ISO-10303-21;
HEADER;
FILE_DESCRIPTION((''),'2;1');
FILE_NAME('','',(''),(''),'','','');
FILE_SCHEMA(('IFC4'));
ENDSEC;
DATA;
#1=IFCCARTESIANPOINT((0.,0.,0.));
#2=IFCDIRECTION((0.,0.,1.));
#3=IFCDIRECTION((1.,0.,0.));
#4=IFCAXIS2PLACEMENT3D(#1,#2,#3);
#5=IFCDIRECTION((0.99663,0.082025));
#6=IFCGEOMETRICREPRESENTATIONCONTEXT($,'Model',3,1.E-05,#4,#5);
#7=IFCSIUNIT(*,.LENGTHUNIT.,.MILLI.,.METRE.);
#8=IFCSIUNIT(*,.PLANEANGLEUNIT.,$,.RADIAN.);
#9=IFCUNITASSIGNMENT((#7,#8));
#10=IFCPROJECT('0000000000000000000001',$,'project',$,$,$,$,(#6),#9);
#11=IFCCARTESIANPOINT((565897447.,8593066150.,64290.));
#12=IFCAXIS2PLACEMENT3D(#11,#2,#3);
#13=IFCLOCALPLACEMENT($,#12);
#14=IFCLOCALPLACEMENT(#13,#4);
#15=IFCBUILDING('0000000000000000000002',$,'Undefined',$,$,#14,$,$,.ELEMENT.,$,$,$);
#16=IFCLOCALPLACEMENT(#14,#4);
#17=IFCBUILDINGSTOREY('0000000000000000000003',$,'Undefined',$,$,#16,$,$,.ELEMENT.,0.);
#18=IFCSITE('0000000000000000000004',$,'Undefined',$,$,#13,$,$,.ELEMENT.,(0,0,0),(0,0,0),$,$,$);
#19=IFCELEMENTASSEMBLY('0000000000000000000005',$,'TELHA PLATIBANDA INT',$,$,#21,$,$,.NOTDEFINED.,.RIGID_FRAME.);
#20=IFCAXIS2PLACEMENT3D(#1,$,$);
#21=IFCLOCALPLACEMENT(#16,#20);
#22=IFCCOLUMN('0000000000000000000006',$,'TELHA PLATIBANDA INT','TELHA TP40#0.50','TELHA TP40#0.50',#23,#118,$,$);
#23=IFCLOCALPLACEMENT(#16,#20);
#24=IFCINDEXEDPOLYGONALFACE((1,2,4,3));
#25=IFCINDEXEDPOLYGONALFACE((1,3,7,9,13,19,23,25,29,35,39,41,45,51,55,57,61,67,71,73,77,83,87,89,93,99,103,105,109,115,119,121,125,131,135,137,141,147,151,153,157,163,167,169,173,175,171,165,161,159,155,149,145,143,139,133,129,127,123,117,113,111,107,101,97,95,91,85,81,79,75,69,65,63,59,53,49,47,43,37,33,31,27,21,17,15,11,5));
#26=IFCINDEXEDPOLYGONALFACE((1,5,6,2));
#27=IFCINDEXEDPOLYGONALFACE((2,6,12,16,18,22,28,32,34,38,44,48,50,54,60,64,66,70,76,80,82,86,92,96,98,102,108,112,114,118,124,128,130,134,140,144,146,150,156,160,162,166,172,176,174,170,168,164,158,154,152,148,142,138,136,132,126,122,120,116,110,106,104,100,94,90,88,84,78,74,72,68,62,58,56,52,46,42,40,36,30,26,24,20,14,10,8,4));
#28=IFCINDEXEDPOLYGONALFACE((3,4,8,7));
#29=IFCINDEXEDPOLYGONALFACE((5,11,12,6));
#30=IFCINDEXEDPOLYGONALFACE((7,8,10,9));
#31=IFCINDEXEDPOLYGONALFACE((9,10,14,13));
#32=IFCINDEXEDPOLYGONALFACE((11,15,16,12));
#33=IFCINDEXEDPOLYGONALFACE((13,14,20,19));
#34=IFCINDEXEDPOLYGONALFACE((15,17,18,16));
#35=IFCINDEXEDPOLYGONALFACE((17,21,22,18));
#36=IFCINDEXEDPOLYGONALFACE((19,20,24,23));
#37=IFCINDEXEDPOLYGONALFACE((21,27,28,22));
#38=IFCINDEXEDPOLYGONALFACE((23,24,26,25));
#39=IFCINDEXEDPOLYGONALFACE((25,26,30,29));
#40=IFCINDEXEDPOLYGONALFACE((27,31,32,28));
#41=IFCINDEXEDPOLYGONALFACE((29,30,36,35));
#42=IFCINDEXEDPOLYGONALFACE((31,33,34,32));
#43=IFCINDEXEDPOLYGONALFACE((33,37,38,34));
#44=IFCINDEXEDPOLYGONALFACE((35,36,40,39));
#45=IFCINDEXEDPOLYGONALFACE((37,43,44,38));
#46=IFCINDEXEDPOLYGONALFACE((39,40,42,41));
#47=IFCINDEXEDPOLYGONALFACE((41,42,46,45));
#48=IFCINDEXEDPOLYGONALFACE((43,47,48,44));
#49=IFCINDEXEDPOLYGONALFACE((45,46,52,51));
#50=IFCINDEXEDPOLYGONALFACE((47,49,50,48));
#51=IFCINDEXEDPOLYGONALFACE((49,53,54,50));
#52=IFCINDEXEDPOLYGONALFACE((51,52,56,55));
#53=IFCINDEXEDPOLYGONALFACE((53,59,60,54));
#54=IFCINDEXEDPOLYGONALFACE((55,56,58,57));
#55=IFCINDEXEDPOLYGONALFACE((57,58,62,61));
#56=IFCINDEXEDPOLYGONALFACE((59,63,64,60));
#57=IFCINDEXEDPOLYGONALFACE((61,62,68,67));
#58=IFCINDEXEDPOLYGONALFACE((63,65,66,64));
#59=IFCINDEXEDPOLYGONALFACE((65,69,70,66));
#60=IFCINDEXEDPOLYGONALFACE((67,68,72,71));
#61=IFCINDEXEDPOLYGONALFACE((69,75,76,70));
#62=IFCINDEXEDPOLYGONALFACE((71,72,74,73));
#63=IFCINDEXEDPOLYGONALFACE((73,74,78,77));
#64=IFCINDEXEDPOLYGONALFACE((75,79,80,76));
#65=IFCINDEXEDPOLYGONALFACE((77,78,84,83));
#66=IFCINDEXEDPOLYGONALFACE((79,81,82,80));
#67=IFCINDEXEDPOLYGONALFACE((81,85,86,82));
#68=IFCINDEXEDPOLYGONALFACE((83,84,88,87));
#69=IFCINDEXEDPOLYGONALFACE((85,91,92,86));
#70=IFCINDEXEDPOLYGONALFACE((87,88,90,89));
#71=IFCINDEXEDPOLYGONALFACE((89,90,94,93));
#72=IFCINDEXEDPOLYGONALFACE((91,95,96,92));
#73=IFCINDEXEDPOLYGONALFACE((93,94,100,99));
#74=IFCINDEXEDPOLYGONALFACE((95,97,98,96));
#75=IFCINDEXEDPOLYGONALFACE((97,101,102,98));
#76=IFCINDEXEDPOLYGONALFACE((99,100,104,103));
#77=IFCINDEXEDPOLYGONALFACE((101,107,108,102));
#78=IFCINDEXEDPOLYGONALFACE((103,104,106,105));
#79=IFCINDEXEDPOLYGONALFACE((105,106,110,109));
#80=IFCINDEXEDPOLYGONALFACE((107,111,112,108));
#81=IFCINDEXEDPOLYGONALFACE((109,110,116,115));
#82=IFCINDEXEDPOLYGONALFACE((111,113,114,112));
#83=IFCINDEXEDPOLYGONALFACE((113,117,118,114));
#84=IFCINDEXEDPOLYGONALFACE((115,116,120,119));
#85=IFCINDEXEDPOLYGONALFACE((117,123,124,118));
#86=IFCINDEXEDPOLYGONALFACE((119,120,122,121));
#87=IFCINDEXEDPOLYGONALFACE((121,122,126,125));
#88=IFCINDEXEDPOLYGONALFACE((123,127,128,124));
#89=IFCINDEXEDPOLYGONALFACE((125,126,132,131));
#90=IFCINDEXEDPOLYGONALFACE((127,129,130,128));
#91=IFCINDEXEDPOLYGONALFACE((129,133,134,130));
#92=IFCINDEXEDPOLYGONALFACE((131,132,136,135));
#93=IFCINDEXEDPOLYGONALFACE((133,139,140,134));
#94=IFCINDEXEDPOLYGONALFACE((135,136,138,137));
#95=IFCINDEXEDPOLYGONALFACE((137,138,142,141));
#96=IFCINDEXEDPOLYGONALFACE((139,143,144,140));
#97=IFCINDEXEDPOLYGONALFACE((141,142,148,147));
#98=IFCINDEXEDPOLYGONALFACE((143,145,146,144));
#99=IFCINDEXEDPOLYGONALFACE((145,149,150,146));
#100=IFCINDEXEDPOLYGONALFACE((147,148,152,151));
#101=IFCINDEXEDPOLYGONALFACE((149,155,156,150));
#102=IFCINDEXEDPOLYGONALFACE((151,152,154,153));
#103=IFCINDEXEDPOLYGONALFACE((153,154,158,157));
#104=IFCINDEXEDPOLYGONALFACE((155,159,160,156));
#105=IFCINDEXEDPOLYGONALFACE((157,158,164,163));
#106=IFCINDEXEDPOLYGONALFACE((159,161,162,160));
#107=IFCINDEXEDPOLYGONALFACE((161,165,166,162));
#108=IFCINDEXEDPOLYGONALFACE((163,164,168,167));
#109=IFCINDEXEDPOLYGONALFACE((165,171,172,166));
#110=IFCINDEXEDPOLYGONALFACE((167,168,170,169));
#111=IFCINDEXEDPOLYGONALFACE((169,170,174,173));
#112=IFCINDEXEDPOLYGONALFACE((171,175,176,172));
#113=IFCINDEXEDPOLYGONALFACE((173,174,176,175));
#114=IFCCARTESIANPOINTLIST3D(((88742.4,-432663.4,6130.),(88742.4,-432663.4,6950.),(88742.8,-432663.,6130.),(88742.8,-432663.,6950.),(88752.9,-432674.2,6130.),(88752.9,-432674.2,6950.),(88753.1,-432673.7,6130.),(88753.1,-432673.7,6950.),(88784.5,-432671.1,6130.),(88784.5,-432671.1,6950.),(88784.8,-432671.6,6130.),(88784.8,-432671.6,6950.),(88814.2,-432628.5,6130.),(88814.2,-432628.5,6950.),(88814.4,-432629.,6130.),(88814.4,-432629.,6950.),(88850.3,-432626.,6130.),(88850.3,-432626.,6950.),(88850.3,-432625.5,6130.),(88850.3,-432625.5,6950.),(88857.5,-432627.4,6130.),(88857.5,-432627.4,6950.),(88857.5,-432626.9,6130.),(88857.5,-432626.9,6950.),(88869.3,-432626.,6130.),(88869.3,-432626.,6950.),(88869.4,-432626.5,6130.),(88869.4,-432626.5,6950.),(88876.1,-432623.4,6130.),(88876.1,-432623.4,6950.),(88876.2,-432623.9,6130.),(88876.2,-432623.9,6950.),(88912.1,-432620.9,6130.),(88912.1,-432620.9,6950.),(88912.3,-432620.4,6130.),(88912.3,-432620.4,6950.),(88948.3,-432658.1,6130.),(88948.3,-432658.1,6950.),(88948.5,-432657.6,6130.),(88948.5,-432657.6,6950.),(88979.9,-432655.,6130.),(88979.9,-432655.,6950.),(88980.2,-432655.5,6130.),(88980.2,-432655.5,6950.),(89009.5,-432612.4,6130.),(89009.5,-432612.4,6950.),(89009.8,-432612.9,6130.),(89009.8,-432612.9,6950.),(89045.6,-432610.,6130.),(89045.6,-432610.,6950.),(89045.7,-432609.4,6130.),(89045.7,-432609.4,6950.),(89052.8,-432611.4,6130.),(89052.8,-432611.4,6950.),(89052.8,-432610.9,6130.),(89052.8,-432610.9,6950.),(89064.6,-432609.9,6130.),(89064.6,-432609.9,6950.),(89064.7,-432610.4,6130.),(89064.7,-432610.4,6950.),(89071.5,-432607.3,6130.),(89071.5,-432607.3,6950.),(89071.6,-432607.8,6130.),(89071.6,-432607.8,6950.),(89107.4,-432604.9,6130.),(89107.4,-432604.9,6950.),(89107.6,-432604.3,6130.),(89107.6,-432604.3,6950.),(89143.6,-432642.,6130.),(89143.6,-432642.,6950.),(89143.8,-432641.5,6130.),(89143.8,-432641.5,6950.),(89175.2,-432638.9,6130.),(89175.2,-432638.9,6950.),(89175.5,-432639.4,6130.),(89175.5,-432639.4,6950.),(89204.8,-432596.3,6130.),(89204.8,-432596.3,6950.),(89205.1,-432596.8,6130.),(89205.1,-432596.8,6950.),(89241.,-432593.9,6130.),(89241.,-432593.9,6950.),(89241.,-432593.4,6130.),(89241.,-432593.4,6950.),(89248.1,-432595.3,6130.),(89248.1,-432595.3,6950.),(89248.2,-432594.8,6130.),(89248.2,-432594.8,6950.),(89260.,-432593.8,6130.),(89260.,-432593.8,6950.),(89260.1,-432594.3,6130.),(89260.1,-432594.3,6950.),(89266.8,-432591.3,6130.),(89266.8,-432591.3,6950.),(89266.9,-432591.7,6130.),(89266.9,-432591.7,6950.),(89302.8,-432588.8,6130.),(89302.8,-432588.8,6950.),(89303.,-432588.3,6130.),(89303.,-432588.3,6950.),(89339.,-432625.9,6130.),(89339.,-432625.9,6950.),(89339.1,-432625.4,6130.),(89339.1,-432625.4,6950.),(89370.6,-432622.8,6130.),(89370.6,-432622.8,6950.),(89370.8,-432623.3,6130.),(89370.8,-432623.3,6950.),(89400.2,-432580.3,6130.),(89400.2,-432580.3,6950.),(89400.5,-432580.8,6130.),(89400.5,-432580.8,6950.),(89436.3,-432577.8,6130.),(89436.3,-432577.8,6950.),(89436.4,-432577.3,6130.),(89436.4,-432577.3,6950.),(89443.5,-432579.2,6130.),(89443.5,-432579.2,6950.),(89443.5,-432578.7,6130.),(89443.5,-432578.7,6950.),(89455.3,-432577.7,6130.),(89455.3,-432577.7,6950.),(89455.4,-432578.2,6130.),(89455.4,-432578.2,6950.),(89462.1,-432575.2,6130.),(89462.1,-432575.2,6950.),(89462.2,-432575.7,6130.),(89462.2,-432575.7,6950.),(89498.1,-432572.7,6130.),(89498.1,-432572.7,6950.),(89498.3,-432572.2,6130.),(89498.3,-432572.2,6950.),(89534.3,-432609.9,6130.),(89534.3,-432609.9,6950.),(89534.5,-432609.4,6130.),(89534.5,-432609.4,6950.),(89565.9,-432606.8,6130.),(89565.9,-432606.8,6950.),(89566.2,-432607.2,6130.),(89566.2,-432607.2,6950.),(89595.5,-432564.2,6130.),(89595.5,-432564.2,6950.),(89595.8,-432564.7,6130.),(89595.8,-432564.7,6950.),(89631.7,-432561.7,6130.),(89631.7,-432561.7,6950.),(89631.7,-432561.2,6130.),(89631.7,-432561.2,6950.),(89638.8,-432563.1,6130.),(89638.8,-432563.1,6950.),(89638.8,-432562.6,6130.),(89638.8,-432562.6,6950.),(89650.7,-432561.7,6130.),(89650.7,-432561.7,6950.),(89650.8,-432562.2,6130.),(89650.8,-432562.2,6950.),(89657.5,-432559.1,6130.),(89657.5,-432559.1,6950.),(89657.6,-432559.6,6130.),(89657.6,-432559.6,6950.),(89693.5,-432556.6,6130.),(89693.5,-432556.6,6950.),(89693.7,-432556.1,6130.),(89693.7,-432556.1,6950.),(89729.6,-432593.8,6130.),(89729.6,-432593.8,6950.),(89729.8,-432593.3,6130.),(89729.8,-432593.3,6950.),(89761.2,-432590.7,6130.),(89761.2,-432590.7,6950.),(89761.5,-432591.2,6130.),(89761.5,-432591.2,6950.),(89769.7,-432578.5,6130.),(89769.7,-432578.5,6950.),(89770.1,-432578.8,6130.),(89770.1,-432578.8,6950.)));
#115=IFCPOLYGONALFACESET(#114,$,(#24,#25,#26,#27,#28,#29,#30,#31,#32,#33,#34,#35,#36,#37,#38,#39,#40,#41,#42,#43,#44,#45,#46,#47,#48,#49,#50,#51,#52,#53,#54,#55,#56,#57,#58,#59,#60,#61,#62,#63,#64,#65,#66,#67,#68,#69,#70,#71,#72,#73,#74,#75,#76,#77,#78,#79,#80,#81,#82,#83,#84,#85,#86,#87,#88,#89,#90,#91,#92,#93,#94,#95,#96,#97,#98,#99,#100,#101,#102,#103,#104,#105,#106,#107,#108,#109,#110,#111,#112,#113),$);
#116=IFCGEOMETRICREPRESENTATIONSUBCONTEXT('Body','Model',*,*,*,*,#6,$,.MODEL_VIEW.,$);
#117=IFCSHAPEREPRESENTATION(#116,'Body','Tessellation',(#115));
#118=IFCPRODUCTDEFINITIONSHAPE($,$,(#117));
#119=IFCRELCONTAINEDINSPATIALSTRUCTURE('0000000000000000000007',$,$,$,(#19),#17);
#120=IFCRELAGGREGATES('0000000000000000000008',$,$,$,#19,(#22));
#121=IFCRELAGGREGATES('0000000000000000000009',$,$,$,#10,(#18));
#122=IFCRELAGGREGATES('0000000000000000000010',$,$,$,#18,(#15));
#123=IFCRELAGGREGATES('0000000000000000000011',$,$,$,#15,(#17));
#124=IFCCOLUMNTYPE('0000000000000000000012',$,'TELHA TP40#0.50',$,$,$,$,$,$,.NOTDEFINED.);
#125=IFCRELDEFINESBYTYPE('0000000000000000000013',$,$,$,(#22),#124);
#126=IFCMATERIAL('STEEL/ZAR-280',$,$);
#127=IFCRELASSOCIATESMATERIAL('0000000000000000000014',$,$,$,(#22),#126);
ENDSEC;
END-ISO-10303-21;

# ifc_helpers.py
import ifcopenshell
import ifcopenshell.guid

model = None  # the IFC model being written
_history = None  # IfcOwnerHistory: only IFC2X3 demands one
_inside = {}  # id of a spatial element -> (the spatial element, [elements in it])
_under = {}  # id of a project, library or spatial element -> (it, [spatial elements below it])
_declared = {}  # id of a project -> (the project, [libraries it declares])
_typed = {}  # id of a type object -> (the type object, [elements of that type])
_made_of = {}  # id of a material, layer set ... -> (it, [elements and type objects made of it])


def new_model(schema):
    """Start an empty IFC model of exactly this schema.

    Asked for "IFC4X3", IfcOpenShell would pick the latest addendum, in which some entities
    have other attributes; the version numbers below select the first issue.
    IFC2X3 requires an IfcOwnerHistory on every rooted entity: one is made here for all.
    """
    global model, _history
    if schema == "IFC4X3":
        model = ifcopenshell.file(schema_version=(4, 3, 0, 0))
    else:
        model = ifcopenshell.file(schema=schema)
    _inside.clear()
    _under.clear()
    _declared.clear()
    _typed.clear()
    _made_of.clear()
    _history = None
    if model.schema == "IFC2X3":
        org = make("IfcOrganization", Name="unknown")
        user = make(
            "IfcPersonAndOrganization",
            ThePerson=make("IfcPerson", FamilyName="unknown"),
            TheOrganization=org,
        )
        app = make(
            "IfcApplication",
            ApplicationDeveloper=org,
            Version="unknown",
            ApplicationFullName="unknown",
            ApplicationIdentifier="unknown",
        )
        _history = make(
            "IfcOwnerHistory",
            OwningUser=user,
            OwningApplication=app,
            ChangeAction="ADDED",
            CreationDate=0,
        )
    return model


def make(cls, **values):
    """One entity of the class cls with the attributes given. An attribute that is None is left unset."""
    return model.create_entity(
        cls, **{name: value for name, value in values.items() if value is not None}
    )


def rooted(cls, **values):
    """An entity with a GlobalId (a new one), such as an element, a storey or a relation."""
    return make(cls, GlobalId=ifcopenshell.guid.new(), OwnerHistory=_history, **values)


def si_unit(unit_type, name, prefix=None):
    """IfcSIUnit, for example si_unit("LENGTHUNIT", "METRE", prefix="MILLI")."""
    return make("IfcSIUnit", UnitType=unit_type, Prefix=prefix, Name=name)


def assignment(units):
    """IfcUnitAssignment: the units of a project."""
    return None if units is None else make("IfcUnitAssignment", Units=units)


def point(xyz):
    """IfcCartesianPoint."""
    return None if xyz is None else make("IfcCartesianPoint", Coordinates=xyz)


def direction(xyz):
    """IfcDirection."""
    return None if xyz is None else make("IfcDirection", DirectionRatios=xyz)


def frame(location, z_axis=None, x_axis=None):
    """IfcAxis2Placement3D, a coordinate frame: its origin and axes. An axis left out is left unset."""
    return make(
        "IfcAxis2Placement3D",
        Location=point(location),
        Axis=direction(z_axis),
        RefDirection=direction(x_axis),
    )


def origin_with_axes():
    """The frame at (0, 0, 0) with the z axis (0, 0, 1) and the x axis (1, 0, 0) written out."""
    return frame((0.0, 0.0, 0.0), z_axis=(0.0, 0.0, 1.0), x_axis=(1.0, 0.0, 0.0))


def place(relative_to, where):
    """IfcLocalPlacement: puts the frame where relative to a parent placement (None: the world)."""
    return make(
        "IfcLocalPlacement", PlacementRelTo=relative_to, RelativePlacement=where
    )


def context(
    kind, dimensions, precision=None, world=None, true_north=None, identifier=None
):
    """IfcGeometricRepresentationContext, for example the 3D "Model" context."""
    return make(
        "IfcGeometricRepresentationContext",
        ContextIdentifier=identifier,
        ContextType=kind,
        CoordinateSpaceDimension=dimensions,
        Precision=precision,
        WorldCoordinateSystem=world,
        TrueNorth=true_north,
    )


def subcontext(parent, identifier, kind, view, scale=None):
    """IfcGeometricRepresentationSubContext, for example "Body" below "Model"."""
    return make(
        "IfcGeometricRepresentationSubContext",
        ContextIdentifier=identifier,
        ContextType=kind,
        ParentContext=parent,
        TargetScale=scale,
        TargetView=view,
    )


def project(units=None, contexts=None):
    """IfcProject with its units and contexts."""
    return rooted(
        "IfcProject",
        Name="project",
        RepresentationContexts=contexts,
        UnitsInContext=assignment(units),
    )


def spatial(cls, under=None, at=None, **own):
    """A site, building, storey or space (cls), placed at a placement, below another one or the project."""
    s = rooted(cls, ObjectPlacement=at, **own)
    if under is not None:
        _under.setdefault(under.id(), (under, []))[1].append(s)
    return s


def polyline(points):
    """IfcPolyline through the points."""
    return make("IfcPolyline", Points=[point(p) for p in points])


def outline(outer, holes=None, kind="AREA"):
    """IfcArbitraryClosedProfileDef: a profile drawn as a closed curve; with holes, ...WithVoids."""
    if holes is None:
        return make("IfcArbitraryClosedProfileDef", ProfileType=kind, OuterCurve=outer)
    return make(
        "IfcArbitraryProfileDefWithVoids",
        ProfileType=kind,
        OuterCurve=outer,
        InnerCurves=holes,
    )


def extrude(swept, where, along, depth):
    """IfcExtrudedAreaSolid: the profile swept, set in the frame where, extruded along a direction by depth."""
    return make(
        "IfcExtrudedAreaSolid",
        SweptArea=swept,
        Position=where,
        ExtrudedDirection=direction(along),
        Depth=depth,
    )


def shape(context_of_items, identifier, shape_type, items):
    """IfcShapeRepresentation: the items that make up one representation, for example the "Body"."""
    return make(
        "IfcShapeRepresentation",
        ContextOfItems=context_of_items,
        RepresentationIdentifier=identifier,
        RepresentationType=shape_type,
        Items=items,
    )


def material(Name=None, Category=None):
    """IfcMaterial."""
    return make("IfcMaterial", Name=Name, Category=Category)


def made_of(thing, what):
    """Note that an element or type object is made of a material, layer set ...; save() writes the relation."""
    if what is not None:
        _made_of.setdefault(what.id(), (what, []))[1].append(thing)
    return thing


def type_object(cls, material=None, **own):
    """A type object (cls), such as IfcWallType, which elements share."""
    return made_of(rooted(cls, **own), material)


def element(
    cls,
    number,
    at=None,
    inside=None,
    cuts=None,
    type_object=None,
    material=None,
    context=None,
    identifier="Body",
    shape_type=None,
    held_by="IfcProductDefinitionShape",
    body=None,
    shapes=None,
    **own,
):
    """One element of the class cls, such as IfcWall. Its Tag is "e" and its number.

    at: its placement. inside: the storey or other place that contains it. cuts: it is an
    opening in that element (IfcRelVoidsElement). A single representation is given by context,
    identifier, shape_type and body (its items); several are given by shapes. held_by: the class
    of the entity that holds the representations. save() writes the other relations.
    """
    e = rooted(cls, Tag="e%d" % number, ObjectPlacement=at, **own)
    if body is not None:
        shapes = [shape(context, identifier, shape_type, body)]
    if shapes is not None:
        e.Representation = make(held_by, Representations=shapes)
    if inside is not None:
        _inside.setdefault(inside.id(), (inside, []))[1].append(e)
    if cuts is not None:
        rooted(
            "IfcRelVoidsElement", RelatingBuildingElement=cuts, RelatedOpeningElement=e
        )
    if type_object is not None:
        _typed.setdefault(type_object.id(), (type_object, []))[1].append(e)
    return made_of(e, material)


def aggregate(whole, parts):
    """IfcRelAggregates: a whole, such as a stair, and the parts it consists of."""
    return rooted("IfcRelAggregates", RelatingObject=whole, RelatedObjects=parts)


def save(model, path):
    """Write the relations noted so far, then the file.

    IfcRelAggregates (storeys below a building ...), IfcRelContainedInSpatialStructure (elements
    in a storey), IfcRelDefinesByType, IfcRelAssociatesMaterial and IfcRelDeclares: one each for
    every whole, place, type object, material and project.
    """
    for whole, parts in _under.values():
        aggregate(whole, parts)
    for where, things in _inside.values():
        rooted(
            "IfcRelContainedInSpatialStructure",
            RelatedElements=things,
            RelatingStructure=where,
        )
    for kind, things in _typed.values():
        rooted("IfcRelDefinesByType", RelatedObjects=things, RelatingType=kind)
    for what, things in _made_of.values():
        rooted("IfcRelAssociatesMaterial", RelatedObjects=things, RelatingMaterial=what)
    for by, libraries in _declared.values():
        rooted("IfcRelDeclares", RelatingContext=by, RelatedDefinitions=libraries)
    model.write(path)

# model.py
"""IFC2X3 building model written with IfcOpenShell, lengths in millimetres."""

from ifc_helpers import new_model, si_unit, direction, frame, origin_with_axes, place, context, subcontext, project, spatial, polyline, outline, extrude, material, type_object, element, aggregate, save


model = new_model("IFC2X3")

# Units and contexts
model_context = context("Model", 3, precision=1e-05, world=origin_with_axes(), true_north=direction((0.99663, 0.082025)))
body_context = subcontext(model_context, "Body", "Model", "MODEL_VIEW")
ifc_project = project(units=[si_unit("LENGTHUNIT", "METRE", prefix="MILLI"), si_unit("PLANEANGLEUNIT", "RADIAN")], contexts=[model_context])

# Site, building, storey
site_placement = place(None, frame((565897447.0, 8593066150.0, 64290.0), z_axis=(0.0, 0.0, 1.0), x_axis=(1.0, 0.0, 0.0)))
site = spatial("IfcSite", under=ifc_project, at=site_placement, Name="Undefined", CompositionType="ELEMENT", RefLatitude=(0, 0, 0), RefLongitude=(0, 0, 0))
building_placement = place(site_placement, origin_with_axes())
building = spatial("IfcBuilding", under=site, at=building_placement, Name="Undefined", CompositionType="ELEMENT")
storey_placement = place(building_placement, origin_with_axes())
storey = spatial("IfcBuildingStorey", under=building, at=storey_placement, Name="Undefined", CompositionType="ELEMENT", Elevation=0.0)

# Element assembly, column
ifc_material_1 = material(Name="STEEL/ZAR-280")
column_type = type_object("IfcColumnType", Name="TELHA TP40#0.50", PredefinedType="NOTDEFINED")
assembly_1_placement = place(storey_placement, origin_with_axes())
assembly_1 = element("IfcElementAssembly", 1, at=assembly_1_placement, inside=storey, Name="TELHA PLATIBANDA INT", AssemblyPlace="NOTDEFINED", PredefinedType="RIGID_FRAME")
column_1_placement = place(assembly_1_placement, frame((89255.8, -432612.5, 6130.0), z_axis=(0.0, 0.0, 1.0), x_axis=(0.082025, -0.99663, 0.0)))
column_1 = element("IfcColumn", 2, at=column_1_placement, type_object=column_type, material=ifc_material_1, Name="TELHA PLATIBANDA INT", Description="TELHA TP40#0.50", ObjectType="TELHA TP40#0.50", context=body_context, shape_type="SweptSolid", body=[
    extrude(outline(polyline([(440.8, -19.8), (473.8, 20.2), (505.8, 20.2), (515.4, 8.6), (515.0, 8.3), (505.6, 19.8), (474.0, 19.8), (441.0, -20.2), (404.7, -20.2), (397.7, -18.2), (385.9, -18.2), (378.9, -20.2), (342.6, -20.2), (309.6, 19.8), (278.0, 19.8), (245.0, -20.2), (208.7, -20.2), (201.7, -18.2), (189.9, -18.2), (182.9, -20.2), (146.6, -20.2), (113.6, 19.8), (82.0, 19.8), (49.0, -20.2), (12.7, -20.2), (5.7, -18.2), (-6.1, -18.2), (-13.1, -20.2), (-49.4, -20.2), (-82.4, 19.8), (-114.0, 19.8), (-147.0, -20.2), (-183.3, -20.2), (-190.3, -18.2), (-202.1, -18.2), (-209.1, -20.2), (-245.4, -20.2), (-278.4, 19.8), (-310.0, 19.8), (-343.0, -20.2), (-379.3, -20.2), (-386.3, -18.2), (-398.1, -18.2), (-405.1, -20.2), (-441.4, -20.2), (-474.4, 19.8), (-506.0, 19.8), (-515.4, 8.3), (-515.8, 8.6), (-506.2, 20.2), (-474.2, 20.2), (-441.2, -19.8), (-405.2, -19.8), (-398.2, -17.8), (-386.2, -17.8), (-379.2, -19.8), (-343.2, -19.8), (-310.2, 20.2), (-278.2, 20.2), (-245.2, -19.8), (-209.2, -19.8), (-202.2, -17.8), (-190.2, -17.8), (-183.2, -19.8), (-147.2, -19.8), (-114.2, 20.2), (-82.2, 20.2), (-49.2, -19.8), (-13.2, -19.8), (-6.2, -17.8), (5.8, -17.8), (12.8, -19.8), (48.8, -19.8), (81.8, 20.2), (113.8, 20.2), (146.8, -19.8), (182.8, -19.8), (189.8, -17.8), (201.8, -17.8), (208.8, -19.8), (244.8, -19.8), (277.8, 20.2), (309.8, 20.2), (342.8, -19.8), (378.8, -19.8), (385.8, -17.8), (397.8, -17.8), (404.8, -19.8), (440.8, -19.8)])), frame((0.0, 0.0, 820.0), z_axis=(0.0, 0.0, -1.0), x_axis=(0.0, 1.0, 0.0)), (0.0, 0.0, 1.0), 820.0),
])
aggregate(assembly_1, [column_1])

save(model, "model.ifc")
